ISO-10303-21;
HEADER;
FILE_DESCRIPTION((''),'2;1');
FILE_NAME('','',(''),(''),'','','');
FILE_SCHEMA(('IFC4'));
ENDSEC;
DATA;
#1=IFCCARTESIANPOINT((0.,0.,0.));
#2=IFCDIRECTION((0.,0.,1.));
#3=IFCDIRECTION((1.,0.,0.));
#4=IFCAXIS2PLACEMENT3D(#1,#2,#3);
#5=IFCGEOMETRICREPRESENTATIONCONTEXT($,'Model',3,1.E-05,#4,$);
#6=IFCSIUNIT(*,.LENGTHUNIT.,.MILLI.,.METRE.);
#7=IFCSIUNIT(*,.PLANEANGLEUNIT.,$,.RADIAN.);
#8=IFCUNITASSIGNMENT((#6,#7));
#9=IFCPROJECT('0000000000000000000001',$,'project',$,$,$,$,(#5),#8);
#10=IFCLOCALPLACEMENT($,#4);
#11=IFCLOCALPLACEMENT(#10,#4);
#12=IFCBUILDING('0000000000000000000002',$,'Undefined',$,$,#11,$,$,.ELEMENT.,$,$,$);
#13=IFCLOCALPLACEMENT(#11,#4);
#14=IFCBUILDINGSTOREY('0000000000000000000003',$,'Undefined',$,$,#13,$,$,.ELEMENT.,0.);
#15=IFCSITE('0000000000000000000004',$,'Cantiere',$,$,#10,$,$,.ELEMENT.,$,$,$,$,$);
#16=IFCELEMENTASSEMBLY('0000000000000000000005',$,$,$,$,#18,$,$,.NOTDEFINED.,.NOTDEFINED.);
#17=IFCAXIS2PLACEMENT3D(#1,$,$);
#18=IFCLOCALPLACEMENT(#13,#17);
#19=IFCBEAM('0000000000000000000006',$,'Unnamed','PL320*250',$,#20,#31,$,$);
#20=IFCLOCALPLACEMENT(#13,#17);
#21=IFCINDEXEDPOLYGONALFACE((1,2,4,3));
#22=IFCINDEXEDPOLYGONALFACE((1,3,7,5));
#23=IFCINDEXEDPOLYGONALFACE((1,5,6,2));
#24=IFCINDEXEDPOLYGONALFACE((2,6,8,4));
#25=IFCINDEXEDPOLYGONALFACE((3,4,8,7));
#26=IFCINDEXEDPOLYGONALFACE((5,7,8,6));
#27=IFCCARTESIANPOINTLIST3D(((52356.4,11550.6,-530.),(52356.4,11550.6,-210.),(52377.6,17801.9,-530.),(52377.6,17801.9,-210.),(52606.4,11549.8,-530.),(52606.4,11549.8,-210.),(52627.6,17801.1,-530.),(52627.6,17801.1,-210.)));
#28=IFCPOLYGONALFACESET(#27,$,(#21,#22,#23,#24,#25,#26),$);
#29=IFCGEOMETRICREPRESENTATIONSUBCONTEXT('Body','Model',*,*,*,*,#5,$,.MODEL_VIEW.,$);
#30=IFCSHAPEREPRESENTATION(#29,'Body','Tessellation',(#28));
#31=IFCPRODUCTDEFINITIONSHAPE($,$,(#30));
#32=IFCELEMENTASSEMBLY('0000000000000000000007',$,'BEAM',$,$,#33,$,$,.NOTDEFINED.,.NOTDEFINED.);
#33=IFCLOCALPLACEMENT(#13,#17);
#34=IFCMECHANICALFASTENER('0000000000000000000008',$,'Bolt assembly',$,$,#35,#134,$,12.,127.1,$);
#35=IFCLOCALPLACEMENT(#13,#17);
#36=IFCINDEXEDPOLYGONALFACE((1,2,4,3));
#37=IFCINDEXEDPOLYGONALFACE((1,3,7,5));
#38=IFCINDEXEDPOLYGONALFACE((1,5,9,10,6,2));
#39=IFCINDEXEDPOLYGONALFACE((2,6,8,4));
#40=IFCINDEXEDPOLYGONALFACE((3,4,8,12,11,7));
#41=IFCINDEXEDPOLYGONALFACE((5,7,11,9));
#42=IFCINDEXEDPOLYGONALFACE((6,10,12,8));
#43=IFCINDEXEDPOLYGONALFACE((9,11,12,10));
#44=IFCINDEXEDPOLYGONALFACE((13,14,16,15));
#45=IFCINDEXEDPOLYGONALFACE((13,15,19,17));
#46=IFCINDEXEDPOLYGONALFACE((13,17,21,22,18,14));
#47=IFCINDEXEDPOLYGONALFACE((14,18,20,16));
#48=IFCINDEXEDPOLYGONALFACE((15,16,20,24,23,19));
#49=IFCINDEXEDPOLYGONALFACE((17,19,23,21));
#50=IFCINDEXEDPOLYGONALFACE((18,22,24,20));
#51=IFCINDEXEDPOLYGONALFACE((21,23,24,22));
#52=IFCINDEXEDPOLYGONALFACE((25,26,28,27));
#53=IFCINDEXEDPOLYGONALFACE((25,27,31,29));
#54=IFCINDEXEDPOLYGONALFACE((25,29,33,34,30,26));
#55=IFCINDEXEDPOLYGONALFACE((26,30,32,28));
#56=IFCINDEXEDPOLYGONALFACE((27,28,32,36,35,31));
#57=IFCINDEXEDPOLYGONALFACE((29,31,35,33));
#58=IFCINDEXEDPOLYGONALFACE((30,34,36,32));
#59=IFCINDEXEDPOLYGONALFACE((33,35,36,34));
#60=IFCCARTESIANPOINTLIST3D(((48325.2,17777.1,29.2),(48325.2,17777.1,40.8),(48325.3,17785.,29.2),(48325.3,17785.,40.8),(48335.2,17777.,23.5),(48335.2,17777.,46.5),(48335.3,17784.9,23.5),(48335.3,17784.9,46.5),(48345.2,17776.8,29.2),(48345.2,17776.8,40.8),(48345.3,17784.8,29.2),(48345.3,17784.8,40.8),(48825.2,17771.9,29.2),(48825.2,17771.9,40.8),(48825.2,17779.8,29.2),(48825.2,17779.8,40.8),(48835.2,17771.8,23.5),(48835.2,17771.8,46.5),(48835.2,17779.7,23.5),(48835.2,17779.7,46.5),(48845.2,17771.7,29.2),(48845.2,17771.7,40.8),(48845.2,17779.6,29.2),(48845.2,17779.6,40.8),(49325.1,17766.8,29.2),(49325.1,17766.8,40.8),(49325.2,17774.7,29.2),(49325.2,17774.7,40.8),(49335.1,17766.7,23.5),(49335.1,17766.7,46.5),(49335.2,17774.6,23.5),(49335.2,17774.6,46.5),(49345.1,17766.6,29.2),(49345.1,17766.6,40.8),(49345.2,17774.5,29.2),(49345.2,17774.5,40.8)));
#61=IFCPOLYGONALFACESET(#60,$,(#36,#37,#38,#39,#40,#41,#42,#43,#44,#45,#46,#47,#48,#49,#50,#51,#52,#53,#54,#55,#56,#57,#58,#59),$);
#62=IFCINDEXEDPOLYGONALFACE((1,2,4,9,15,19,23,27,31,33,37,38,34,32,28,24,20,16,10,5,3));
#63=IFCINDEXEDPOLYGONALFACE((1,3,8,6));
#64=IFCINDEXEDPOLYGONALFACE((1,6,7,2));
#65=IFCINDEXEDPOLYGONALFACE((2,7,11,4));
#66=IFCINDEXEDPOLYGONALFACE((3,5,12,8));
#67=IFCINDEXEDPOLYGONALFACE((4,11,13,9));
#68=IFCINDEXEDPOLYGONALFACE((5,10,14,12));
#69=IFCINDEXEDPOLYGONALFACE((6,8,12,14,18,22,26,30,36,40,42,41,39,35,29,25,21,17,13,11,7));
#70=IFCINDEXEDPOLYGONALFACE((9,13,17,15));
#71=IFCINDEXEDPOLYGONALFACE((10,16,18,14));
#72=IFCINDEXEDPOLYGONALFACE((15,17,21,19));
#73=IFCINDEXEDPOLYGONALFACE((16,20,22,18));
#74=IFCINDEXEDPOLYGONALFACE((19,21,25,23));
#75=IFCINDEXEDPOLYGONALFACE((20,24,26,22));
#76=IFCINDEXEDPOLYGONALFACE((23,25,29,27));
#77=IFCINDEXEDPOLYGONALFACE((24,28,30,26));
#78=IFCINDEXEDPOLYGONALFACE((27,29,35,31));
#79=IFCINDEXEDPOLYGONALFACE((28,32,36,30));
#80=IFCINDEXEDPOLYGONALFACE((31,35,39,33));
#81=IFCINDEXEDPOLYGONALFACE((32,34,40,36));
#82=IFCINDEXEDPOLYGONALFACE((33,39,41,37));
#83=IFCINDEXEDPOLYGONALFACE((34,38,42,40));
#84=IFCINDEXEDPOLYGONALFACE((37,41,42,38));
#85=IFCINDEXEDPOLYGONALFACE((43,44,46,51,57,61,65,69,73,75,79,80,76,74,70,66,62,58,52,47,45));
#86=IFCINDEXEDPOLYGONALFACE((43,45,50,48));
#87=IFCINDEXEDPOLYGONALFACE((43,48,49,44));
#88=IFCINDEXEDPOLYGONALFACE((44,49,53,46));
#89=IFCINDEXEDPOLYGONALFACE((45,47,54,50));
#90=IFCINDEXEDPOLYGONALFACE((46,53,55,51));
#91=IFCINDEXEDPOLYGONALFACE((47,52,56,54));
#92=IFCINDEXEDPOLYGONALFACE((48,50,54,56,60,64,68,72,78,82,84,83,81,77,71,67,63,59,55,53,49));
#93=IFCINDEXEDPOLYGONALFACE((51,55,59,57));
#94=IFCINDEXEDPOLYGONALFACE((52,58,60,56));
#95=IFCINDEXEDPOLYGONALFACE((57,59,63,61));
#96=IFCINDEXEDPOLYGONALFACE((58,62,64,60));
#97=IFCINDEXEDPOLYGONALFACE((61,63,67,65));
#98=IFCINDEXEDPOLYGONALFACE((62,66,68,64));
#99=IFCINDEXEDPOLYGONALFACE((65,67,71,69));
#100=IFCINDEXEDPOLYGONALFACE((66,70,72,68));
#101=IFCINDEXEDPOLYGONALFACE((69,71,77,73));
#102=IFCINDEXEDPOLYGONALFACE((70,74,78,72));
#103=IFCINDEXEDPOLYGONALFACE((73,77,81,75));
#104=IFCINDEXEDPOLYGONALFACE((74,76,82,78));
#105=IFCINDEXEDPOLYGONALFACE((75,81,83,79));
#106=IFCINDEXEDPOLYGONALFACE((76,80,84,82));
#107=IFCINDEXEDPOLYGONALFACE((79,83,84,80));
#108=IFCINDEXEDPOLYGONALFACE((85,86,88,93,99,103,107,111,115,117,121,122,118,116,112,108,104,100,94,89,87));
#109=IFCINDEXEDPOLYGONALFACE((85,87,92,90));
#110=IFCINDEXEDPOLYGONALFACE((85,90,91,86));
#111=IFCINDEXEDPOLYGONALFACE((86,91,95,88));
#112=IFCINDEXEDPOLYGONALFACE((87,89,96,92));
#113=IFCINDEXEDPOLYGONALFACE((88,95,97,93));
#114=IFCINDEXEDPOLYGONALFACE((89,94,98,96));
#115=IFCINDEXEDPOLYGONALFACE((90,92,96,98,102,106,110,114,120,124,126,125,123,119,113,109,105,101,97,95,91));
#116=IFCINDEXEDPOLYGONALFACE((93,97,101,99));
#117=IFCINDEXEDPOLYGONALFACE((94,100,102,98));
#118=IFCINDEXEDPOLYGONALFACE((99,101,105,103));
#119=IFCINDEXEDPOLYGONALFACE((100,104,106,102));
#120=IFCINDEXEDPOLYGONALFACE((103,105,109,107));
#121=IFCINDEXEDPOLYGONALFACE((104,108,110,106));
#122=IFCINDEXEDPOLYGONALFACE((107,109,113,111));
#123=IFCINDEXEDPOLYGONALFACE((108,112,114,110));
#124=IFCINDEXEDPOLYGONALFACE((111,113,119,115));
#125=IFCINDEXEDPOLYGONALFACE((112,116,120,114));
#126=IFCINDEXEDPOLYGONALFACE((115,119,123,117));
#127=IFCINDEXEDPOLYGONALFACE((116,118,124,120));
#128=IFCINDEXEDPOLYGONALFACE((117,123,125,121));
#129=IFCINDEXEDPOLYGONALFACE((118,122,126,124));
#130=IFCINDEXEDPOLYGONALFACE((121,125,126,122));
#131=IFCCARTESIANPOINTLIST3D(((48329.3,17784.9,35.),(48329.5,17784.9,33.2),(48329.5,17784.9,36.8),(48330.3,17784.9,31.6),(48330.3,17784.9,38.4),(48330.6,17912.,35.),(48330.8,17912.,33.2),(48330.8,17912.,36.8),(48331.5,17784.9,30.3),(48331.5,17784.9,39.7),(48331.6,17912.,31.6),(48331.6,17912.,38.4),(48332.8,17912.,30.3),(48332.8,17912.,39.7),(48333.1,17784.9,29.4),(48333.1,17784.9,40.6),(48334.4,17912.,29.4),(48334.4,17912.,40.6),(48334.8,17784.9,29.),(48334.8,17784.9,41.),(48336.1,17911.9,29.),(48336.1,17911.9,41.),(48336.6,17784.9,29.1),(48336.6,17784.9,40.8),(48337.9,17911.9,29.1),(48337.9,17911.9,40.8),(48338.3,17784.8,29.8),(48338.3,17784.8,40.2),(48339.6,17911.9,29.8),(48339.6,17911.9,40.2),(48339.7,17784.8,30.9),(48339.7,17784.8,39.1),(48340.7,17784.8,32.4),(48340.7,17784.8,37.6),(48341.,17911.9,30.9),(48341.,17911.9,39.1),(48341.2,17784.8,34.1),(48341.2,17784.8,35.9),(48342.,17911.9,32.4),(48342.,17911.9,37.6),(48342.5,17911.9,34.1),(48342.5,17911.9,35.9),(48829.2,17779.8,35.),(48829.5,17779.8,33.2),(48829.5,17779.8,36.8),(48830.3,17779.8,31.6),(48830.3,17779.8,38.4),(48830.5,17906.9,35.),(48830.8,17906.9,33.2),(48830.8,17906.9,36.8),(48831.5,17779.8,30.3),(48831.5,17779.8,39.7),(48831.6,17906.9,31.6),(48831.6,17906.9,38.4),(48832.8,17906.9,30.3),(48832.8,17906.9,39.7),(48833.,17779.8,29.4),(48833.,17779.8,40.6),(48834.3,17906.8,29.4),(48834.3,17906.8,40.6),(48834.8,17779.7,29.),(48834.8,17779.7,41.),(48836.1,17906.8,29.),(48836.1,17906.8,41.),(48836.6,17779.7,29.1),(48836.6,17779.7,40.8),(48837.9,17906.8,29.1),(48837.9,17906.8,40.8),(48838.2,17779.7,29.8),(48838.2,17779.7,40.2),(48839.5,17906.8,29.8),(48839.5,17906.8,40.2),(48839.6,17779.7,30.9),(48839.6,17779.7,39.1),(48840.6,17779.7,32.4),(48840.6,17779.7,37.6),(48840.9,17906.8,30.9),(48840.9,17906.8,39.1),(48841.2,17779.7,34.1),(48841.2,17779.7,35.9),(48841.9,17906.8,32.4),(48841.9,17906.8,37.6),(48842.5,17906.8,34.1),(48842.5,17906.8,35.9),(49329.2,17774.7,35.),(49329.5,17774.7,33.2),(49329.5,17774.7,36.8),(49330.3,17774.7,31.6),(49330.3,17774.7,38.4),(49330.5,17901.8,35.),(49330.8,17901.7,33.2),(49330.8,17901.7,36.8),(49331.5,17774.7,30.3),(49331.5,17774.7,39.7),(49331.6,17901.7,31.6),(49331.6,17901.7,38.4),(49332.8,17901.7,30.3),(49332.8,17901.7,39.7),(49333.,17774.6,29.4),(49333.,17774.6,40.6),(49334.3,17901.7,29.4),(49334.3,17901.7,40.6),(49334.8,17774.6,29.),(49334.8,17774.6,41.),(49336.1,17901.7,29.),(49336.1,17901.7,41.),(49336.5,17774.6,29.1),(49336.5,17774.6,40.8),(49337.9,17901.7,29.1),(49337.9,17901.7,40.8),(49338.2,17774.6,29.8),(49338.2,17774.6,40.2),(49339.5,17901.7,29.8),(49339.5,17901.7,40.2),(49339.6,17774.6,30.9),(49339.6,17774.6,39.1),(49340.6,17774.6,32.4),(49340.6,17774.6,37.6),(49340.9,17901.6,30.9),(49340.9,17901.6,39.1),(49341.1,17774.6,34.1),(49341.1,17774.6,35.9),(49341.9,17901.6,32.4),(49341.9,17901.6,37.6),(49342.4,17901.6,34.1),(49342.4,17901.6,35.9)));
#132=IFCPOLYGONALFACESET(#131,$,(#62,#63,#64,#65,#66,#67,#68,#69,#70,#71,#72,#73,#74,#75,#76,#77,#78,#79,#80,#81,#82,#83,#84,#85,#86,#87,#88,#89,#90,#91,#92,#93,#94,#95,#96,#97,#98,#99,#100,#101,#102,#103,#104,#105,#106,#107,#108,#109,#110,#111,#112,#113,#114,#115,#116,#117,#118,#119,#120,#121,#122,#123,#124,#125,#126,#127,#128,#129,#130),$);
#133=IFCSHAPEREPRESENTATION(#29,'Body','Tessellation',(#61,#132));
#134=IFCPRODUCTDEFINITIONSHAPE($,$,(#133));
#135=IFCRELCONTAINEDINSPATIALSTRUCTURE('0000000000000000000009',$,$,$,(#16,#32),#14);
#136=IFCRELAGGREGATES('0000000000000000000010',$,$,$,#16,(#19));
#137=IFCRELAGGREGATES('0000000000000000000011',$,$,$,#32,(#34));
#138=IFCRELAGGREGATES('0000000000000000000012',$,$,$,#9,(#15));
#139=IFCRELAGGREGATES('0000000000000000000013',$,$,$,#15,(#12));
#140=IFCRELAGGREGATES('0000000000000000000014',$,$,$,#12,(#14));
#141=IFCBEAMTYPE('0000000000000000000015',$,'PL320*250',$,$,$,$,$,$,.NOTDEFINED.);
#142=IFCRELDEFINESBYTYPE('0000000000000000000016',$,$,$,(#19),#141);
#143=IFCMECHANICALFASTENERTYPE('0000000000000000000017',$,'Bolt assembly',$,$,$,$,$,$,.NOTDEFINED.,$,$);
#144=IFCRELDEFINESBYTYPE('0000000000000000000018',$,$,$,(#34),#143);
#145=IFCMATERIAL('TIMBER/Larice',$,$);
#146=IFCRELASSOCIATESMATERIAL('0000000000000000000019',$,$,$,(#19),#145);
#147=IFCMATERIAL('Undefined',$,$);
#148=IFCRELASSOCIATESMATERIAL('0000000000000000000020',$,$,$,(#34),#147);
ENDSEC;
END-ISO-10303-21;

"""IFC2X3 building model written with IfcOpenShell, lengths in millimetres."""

from ifc_helpers import new_model, si_unit, frame, origin_with_axes, origin_2d_with_axis, place, context, subcontext, project, spatial, polyline, rectangle, circle, outline, extrude, source, transform, mapped, material, type_object, element, aggregate, save


model = new_model("IFC2X3")

# Units and contexts
model_context = context("Model", 3, precision=1e-05, world=origin_with_axes())
body_context = subcontext(model_context, "Body", "Model", "MODEL_VIEW")
ifc_project = project(units=[si_unit("LENGTHUNIT", "METRE", prefix="MILLI"), si_unit("PLANEANGLEUNIT", "RADIAN")], contexts=[model_context])

# Site, building, storey
site_placement = place(None, origin_with_axes())
site = spatial("IfcSite", under=ifc_project, at=site_placement, Name="Cantiere", CompositionType="ELEMENT")
building_placement = place(site_placement, origin_with_axes())
building = spatial("IfcBuilding", under=site, at=building_placement, Name="Undefined", CompositionType="ELEMENT")
storey_placement = place(building_placement, origin_with_axes())
storey = spatial("IfcBuildingStorey", under=building, at=storey_placement, Name="Undefined", CompositionType="ELEMENT", Elevation=0.0)

# Element assembly, beam
ifc_material_1 = material(Name="TIMBER/Larice")
beam_type_1 = type_object("IfcBeamType", Name="PL320*250", PredefinedType="NOTDEFINED")
assembly_1_placement = place(storey_placement, origin_with_axes())
assembly_1 = element("IfcElementAssembly", 1, at=assembly_1_placement, inside=storey, AssemblyPlace="NOTDEFINED", PredefinedType="NOTDEFINED")
beam_1_placement = place(assembly_1_placement, frame((52502.6, 17801.5, -370.0), z_axis=(0.0, 0.0, 1.0), x_axis=(-0.003388, -0.999994, 0.0)))
beam_1 = element("IfcBeam", 2, at=beam_1_placement, type_object=beam_type_1, material=ifc_material_1, Name="Unnamed", Description="PL320*250", context=body_context, shape_type="SweptSolid", body=[
    extrude(rectangle(XDim=250.0, YDim=320.0, at=origin_2d_with_axis()), frame((6251.3, 0.0, 0.0), z_axis=(-1.0, 0.0, 0.0), x_axis=(0.0, -1.0, 0.0)), (0.0, 0.0, 1.0), 6251.4),
])
aggregate(assembly_1, [beam_1])

# Shared definitions
mechanical_fastener_type = type_object("IfcMechanicalFastenerType", Name="Bolt assembly")

# Element assembly
assembly_2_placement = place(storey_placement, origin_with_axes())
assembly_2 = element("IfcElementAssembly", 3, at=assembly_2_placement, inside=storey, Name="BEAM", AssemblyPlace="NOTDEFINED", PredefinedType="NOTDEFINED")

# Mechanical fastener
ifc_material_2 = material(Name="Undefined")
shared_shape_1 = source(origin_with_axes(), body_context, "Body", "SweptSolid", [
    extrude(outline(polyline([(10.0, -5.8), (10.0, 5.8), (0.0, 11.5), (-10.0, 5.8), (-10.0, -5.8), (0.0, -11.5), (10.0, -5.8)])), frame((0.0, -135.0, 0.0), z_axis=(0.0, 1.0, 0.0), x_axis=(1.0, 0.0, 0.0)), (0.0, 0.0, 1.0), 7.9),
    extrude(circle(Radius=6.0, at=origin_2d_with_axis()), frame((0.0, -127.1, 0.0), z_axis=(0.0, 1.0, 0.0), x_axis=(1.0, 0.0, 0.0)), (0.0, 0.0, 1.0), 127.1),
])
mechanical_fastener_1_placement = place(assembly_2_placement, frame((49336.5, 17901.7, 35.0), z_axis=(0.0, 0.000001, -1.0), x_axis=(-0.999947, 0.010256, 0.0)))
mechanical_fastener_1 = element("IfcMechanicalFastener", 4, at=mechanical_fastener_1_placement, type_object=mechanical_fastener_type, material=ifc_material_2, Name="Bolt assembly", NominalDiameter=12.0, NominalLength=127.1, context=body_context, shape_type="MappedRepresentation", body=[
    mapped(shared_shape_1, transform((0.0, 0.0, 0.0))),
    mapped(shared_shape_1, transform((500.0, 0.0, 0.0))),
    mapped(shared_shape_1, transform((1000.0, 0.0, 0.0))),
])
aggregate(assembly_2, [mechanical_fastener_1])

save(model, "model.ifc")
